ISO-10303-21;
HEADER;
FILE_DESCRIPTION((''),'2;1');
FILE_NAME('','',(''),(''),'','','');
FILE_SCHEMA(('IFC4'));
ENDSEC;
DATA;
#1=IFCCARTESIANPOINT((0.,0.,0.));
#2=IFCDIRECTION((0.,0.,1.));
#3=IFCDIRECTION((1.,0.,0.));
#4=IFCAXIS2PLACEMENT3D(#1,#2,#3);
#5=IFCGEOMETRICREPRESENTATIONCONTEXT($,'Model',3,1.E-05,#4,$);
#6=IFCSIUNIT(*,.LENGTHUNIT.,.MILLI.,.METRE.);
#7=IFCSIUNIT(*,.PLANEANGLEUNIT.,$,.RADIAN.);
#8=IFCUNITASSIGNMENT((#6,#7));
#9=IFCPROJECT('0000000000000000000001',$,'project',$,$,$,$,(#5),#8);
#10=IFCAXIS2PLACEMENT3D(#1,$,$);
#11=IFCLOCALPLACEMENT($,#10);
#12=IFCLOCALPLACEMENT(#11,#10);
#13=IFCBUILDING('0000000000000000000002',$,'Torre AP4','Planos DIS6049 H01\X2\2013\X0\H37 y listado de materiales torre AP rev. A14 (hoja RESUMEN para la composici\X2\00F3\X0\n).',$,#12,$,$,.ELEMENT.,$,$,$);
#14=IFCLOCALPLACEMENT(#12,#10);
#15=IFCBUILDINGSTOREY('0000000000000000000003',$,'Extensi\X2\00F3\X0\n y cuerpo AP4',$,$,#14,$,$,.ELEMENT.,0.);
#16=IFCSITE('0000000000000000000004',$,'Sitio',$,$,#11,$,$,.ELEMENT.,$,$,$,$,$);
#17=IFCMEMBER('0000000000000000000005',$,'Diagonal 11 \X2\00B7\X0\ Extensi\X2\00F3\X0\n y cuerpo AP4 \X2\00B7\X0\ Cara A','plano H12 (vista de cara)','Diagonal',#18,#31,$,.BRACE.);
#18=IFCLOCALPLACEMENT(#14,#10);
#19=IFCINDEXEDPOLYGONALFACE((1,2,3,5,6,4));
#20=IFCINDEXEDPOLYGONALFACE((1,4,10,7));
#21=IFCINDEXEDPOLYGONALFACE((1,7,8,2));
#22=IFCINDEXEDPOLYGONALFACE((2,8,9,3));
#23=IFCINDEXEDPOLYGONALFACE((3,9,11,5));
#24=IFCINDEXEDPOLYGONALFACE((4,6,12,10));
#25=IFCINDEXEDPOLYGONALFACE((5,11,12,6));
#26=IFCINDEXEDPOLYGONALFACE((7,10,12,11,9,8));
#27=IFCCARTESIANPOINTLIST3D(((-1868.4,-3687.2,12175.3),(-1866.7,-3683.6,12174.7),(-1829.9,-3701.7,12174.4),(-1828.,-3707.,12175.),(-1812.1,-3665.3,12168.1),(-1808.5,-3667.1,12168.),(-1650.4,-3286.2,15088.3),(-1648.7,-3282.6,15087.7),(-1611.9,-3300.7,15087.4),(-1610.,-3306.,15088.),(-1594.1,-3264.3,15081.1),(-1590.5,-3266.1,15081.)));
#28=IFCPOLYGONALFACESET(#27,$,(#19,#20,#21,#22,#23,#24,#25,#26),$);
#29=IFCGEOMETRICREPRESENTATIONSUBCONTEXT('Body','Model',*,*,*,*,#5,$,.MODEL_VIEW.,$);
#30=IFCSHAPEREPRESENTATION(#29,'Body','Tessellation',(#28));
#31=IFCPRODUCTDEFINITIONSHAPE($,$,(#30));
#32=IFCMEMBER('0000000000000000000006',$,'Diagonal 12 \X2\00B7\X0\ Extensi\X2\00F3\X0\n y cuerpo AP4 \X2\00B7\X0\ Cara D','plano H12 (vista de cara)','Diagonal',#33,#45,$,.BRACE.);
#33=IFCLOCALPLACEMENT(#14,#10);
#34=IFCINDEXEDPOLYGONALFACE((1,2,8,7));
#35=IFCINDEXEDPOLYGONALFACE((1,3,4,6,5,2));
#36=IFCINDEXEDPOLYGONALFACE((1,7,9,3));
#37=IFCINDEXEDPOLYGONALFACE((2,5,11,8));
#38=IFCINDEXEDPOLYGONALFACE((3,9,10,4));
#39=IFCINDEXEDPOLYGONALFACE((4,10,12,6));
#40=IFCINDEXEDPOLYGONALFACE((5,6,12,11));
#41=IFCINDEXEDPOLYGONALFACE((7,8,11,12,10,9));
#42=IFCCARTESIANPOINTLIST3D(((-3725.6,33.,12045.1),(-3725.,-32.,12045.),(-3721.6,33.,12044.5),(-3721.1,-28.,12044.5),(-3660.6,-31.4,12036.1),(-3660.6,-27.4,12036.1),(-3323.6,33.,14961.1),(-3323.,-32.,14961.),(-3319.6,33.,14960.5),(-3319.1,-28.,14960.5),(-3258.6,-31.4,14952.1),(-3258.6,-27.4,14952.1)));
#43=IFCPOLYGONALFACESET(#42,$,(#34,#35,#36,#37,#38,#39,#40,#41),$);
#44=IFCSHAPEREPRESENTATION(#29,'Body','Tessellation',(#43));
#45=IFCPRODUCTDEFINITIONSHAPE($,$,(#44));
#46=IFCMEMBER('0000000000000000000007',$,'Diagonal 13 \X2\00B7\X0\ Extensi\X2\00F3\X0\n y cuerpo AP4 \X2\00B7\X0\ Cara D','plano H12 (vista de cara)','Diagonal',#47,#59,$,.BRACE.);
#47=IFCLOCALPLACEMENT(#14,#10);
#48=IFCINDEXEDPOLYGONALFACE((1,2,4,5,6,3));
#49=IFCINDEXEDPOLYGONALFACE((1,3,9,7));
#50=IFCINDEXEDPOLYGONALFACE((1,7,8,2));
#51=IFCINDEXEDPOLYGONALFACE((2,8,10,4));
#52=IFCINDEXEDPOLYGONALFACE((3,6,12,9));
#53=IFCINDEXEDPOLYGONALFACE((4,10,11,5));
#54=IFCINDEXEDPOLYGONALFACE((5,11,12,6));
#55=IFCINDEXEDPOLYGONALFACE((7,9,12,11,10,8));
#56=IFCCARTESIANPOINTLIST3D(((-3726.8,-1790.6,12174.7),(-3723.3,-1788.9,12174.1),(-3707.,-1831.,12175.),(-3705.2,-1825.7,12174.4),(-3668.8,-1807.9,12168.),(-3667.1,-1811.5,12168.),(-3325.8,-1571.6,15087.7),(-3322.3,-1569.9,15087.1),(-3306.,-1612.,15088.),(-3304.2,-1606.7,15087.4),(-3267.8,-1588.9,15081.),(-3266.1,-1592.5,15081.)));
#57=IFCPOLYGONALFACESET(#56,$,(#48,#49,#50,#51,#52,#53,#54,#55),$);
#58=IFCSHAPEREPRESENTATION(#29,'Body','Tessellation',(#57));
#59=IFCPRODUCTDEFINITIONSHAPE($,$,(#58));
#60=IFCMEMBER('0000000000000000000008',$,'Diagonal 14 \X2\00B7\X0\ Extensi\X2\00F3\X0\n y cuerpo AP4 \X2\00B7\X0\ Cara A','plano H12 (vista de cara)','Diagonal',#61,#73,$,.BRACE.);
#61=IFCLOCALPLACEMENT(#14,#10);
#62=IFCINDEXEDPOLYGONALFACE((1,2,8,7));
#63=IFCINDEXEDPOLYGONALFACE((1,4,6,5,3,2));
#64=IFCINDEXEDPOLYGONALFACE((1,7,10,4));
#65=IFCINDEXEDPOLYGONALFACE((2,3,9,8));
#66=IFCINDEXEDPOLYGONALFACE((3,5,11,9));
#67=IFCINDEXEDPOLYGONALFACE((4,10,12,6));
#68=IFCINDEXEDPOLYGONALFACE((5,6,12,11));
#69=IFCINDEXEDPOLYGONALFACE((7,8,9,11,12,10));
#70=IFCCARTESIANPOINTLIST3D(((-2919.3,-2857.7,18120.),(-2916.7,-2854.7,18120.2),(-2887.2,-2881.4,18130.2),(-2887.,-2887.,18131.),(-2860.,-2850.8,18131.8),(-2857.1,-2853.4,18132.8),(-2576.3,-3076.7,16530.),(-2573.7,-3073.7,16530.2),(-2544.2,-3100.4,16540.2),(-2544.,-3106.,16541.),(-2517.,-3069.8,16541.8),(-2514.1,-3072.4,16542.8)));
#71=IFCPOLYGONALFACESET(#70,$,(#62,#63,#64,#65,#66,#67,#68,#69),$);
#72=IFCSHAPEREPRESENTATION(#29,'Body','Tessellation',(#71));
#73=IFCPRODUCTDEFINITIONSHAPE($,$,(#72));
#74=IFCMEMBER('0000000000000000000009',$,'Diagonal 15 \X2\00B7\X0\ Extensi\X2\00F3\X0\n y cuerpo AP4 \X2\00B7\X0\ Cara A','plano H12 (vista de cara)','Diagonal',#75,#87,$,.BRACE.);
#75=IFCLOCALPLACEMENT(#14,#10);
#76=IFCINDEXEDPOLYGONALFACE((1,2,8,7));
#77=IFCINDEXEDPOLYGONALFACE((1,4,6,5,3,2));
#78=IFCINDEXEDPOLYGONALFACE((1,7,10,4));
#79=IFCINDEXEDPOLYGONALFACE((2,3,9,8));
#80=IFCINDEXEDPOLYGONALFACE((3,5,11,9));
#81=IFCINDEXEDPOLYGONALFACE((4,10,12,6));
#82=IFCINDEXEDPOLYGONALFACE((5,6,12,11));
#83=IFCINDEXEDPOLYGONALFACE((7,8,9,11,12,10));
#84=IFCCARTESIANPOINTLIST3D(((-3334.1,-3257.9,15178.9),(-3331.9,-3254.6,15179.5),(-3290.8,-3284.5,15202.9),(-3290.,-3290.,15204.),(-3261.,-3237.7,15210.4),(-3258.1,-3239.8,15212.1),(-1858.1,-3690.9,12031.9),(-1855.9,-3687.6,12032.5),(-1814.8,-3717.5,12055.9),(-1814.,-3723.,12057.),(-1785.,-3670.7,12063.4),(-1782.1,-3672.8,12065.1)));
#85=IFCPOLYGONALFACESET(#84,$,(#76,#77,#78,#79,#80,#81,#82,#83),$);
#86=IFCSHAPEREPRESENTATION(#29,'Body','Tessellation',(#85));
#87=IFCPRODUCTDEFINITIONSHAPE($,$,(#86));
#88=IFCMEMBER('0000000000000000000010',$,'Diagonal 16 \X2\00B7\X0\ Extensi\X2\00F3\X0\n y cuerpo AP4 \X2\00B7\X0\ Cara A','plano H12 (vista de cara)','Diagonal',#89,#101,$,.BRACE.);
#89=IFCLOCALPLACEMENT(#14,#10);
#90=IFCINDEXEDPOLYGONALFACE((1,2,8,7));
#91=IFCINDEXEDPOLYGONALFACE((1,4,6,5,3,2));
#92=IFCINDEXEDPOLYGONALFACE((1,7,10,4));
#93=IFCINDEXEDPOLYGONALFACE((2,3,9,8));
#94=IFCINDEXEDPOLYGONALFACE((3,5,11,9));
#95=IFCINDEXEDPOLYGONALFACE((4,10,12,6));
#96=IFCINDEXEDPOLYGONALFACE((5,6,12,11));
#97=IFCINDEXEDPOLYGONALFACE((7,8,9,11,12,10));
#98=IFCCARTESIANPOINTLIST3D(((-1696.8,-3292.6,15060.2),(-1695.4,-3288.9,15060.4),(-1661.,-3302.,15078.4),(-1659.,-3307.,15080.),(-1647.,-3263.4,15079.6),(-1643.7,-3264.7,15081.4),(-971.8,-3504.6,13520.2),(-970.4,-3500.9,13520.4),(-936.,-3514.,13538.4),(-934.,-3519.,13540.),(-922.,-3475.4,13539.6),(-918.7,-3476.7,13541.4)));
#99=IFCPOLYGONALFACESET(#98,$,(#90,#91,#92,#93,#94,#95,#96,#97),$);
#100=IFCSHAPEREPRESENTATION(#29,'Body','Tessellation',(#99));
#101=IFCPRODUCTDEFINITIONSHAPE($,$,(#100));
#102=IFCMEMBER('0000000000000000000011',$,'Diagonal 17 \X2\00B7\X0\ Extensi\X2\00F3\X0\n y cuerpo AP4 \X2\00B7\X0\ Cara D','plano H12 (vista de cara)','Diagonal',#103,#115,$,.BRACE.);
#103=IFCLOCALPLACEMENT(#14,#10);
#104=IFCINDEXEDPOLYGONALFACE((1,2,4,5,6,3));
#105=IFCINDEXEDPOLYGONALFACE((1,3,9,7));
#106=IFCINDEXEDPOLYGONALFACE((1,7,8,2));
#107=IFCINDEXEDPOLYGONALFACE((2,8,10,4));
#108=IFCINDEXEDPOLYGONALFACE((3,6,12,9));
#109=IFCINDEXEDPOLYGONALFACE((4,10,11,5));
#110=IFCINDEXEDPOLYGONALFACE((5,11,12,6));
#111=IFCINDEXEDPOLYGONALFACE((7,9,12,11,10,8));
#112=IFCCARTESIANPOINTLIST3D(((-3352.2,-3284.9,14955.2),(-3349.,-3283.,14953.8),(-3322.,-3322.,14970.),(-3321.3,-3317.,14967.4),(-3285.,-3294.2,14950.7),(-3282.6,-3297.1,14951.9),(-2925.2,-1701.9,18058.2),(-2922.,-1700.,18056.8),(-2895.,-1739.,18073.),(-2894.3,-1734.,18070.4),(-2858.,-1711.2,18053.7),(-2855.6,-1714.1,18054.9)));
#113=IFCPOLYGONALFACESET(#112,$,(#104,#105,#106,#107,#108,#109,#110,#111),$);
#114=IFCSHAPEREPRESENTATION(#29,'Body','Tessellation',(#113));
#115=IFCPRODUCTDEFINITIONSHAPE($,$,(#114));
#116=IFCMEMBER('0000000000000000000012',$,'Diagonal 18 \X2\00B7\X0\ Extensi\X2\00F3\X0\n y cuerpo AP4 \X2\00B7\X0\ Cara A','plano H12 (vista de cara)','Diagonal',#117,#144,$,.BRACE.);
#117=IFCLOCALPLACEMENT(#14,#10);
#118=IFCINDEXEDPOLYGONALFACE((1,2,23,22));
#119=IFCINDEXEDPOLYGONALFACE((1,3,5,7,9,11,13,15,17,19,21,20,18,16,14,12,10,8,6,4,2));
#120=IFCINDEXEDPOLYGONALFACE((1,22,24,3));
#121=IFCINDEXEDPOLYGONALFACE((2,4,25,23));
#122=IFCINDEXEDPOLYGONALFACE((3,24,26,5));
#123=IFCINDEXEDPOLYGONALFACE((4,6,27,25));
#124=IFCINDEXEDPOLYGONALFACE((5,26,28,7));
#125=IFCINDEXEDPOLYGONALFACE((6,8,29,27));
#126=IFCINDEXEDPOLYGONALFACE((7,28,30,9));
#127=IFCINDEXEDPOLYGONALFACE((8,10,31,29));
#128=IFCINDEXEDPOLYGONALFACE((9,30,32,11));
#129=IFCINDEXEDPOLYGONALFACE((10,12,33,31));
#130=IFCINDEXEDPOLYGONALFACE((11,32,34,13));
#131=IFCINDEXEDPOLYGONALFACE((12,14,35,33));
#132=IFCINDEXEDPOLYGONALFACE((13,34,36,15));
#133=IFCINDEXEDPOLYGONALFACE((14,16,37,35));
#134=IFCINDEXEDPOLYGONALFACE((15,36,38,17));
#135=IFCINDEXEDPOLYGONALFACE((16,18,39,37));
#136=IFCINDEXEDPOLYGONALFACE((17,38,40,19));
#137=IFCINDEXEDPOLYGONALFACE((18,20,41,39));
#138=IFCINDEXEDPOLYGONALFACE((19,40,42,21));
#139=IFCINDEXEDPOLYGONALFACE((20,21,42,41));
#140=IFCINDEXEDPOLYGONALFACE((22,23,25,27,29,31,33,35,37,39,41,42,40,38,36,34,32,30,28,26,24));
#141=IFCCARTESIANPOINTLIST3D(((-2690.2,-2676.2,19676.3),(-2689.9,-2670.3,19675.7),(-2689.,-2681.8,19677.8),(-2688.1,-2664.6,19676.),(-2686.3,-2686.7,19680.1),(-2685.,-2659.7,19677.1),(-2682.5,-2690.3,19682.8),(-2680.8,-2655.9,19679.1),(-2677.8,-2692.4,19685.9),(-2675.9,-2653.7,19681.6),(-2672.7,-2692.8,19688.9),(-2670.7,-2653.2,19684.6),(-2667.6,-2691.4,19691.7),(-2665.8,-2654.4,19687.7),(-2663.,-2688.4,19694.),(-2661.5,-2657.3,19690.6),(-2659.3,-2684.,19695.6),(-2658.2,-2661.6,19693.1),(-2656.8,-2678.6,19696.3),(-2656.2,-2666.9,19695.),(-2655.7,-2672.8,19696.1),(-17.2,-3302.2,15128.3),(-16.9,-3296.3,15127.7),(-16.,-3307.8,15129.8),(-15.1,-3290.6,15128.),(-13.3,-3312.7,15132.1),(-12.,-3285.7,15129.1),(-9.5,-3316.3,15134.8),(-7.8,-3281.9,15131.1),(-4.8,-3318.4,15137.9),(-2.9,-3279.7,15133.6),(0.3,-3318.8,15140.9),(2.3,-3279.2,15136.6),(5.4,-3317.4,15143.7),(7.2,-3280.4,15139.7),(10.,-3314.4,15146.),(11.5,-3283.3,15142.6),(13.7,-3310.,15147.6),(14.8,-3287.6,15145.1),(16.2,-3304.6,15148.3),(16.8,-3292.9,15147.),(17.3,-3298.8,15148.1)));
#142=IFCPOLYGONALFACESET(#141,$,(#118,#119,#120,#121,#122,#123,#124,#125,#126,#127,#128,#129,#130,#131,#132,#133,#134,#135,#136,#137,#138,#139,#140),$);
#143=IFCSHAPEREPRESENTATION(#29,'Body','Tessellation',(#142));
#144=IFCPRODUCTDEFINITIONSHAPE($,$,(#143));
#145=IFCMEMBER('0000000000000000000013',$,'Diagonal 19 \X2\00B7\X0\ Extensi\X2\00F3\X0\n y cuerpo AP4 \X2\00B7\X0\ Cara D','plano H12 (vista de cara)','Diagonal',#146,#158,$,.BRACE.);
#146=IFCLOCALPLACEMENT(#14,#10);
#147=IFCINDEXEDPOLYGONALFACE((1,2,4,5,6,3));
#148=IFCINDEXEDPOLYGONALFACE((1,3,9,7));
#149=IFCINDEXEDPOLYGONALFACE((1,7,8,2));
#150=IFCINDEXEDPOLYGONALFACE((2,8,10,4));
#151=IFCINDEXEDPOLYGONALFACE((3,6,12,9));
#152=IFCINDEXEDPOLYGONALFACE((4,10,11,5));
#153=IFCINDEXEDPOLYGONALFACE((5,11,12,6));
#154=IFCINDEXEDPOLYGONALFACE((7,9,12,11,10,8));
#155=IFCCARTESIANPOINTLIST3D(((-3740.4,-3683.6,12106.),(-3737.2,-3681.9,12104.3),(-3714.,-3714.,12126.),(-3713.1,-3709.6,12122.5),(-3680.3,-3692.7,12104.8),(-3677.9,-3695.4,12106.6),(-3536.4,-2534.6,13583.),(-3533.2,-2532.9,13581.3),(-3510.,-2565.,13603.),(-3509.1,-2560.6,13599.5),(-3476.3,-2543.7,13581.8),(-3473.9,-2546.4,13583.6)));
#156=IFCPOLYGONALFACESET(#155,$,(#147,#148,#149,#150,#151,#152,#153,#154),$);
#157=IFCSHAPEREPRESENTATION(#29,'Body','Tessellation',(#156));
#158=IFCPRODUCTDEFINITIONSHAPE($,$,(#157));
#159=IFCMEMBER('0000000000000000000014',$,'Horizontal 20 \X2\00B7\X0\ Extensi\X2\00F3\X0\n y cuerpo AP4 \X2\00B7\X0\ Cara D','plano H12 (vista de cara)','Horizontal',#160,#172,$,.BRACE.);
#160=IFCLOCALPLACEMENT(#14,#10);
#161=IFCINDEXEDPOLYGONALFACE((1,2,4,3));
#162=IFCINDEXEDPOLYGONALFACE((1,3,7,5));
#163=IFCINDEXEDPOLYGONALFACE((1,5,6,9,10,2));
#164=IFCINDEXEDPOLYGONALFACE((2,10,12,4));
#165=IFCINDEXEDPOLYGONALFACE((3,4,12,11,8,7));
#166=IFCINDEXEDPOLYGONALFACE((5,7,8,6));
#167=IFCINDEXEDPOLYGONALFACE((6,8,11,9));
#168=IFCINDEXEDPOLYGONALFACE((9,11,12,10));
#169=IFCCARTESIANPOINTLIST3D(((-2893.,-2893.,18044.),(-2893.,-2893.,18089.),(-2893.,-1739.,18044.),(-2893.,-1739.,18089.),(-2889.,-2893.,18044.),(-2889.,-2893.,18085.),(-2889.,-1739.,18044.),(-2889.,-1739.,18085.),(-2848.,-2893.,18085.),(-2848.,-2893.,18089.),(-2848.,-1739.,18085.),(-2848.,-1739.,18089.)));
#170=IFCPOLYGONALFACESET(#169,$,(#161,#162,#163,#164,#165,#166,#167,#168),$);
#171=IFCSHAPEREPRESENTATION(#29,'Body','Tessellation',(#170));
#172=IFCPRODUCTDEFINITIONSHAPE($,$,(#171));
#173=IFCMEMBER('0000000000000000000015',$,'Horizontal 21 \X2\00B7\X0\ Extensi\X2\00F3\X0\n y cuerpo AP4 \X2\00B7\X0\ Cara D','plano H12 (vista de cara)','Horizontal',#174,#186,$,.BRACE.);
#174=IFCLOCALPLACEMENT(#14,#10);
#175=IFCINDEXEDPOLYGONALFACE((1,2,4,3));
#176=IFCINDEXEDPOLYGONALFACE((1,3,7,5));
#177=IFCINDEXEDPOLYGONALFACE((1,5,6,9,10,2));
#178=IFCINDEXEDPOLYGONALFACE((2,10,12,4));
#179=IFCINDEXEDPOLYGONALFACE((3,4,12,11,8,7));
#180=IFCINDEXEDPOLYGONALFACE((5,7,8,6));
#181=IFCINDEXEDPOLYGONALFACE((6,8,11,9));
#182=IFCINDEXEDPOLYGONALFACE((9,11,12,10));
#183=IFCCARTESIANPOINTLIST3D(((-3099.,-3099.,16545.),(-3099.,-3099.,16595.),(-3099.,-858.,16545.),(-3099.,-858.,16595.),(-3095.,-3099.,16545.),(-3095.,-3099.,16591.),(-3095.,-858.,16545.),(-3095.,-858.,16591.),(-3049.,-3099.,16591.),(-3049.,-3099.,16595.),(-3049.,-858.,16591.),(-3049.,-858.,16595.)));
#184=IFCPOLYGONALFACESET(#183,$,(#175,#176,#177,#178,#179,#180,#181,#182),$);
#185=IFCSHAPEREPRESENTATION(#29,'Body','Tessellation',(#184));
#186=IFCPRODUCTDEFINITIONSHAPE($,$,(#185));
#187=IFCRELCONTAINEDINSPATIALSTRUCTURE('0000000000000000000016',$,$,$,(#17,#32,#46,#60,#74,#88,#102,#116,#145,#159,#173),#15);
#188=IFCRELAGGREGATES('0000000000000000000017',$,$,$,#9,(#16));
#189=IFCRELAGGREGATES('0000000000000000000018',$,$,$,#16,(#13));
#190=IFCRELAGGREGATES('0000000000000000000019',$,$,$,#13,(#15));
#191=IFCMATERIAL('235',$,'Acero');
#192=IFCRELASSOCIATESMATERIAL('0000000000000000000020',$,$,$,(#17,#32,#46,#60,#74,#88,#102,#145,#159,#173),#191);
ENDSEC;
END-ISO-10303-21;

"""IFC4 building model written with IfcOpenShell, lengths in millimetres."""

from ifc_helpers import new_model, si_unit, frame, frame_2d, origin, origin_with_axes, place, context, subcontext, project, spatial, circle, l_section, extrude, material, element, save


model = new_model("IFC4")

# Units and contexts
model_context = context("Model", 3, precision=1e-05, world=origin_with_axes())
body_context = subcontext(model_context, "Body", "Model", "MODEL_VIEW")
ifc_project = project(units=[si_unit("LENGTHUNIT", "METRE", prefix="MILLI"), si_unit("PLANEANGLEUNIT", "RADIAN")], contexts=[model_context])

# Site, building, storey
site_placement = place(None, origin())
site = spatial("IfcSite", under=ifc_project, at=site_placement, Name="Sitio", CompositionType="ELEMENT")
building_placement = place(site_placement, origin())
building = spatial("IfcBuilding", under=site, at=building_placement, Name="Torre AP4", Description="Planos DIS6049 H01–H37 y listado de materiales torre AP rev. A14 (hoja RESUMEN para la composición).", CompositionType="ELEMENT")
storey_placement = place(building_placement, origin())
storey = spatial("IfcBuildingStorey", under=building, at=storey_placement, Name="Extensión y cuerpo AP4", CompositionType="ELEMENT", Elevation=0.0)

# Members
ifc_material_1 = material(Name="235", Category="Acero")
member_1_placement = place(storey_placement, frame((-1828.0, -3707.0, 12175.0), z_axis=(0.073935, 0.135999, 0.987946), x_axis=(0.43397, 0.887553, -0.154657)))
element("IfcMember", 1, at=member_1_placement, inside=storey, material=ifc_material_1, Name="Diagonal 11 · Extensión y cuerpo AP4 · Cara A", Description="plano H12 (vista de cara)", ObjectType="Diagonal", PredefinedType="BRACE", context=body_context, shape_type="SweptSolid", body=[
    extrude(l_section(Depth=45.0, Width=45.0, Thickness=4.0, at=frame_2d((22.5, 22.5))), None, (0.0, 0.0, 1.0), 2948.5),
])
member_2_placement = place(storey_placement, frame((-3725.0, -32.0, 12045.0), z_axis=(0.136568, 0.0, 0.990631), x_axis=(0.990589, 0.009166, -0.136563)))
element("IfcMember", 2, at=member_2_placement, inside=storey, material=ifc_material_1, Name="Diagonal 12 · Extensión y cuerpo AP4 · Cara D", Description="plano H12 (vista de cara)", ObjectType="Diagonal", PredefinedType="BRACE", context=body_context, shape_type="SweptSolid", body=[
    extrude(l_section(Depth=65.0, Width=65.0, Thickness=4.0, at=frame_2d((32.5, 32.5))), None, (0.0, 0.0, 1.0), 2943.6),
])
member_3_placement = place(storey_placement, frame((-3707.0, -1831.0, 12175.0), z_axis=(0.135996, 0.074272, 0.987921), x_axis=(0.887298, 0.434439, -0.154806)))
element("IfcMember", 3, at=member_3_placement, inside=storey, material=ifc_material_1, Name="Diagonal 13 · Extensión y cuerpo AP4 · Cara D", Description="plano H12 (vista de cara)", ObjectType="Diagonal", PredefinedType="BRACE", context=body_context, shape_type="SweptSolid", body=[
    extrude(l_section(Depth=45.0, Width=45.0, Thickness=4.0, at=frame_2d((22.5, 22.5))), None, (0.0, 0.0, 1.0), 2948.6),
])
member_4_placement = place(storey_placement, frame((-2544.0, -3106.0, 16541.0), z_axis=(-0.208987, 0.133435, 0.968772), x_axis=(0.663414, 0.747172, 0.040202)))
element("IfcMember", 4, at=member_4_placement, inside=storey, material=ifc_material_1, Name="Diagonal 14 · Extensión y cuerpo AP4 · Cara A", Description="plano H12 (vista de cara)", ObjectType="Diagonal", PredefinedType="BRACE", context=body_context, shape_type="SweptSolid", body=[
    extrude(l_section(Depth=45.0, Width=45.0, Thickness=4.0, at=frame_2d((22.5, 22.5))), None, (0.0, 0.0, 1.0), 1641.3),
])
member_5_placement = place(storey_placement, frame((-1814.0, -3723.0, 12057.0), z_axis=(-0.421376, 0.123615, 0.898422), x_axis=(0.531937, 0.836041, 0.134456)))
element("IfcMember", 5, at=member_5_placement, inside=storey, material=ifc_material_1, Name="Diagonal 15 · Extensión y cuerpo AP4 · Cara A", Description="plano H12 (vista de cara)", ObjectType="Diagonal", PredefinedType="BRACE", context=body_context, shape_type="SweptSolid", body=[
    extrude(l_section(Depth=60.0, Width=60.0, Thickness=4.0, at=frame_2d((30.0, 30.0))), None, (0.0, 0.0, 1.0), 3502.8),
])
member_6_placement = place(storey_placement, frame((-934.0, -3519.0, 13540.0), z_axis=(-0.422673, 0.123595, 0.897815), x_axis=(0.34071, 0.939656, 0.031044)))
element("IfcMember", 6, at=member_6_placement, inside=storey, material=ifc_material_1, Name="Diagonal 16 · Extensión y cuerpo AP4 · Cara A", Description="plano H12 (vista de cara)", ObjectType="Diagonal", PredefinedType="BRACE", context=body_context, shape_type="SweptSolid", body=[
    extrude(l_section(Depth=45.0, Width=45.0, Thickness=4.0, at=frame_2d((22.5, 22.5))), None, (0.0, 0.0, 1.0), 1715.3),
])
member_7_placement = place(storey_placement, frame((-3322.0, -3322.0, 14970.0), z_axis=(0.121669, 0.451057, 0.884163), x_axis=(0.788239, 0.497452, -0.362244)))
element("IfcMember", 7, at=member_7_placement, inside=storey, material=ifc_material_1, Name="Diagonal 17 · Extensión y cuerpo AP4 · Cara D", Description="plano H12 (vista de cara)", ObjectType="Diagonal", PredefinedType="BRACE", context=body_context, shape_type="SweptSolid", body=[
    extrude(l_section(Depth=50.0, Width=50.0, Thickness=4.0, at=frame_2d((25.0, 25.0))), None, (0.0, 0.0, 1.0), 3509.5),
])
member_8_placement = place(storey_placement, frame((0.0, -3299.0, 15138.0), z_axis=(-0.503167, 0.117839, 0.856118), x_axis=(0.360959, 0.928763, 0.084309)))
element("IfcMember", 8, at=member_8_placement, inside=storey, Name="Diagonal 18 · Extensión y cuerpo AP4 · Cara A", Description="plano H12 (vista de cara)", ObjectType="Diagonal", PredefinedType="BRACE", context=body_context, shape_type="SweptSolid", body=[
    extrude(circle(Radius=20.0), None, (0.0, 0.0, 1.0), 5312.4),
])
member_9_placement = place(storey_placement, frame((-3714.0, -3714.0, 12126.0), z_axis=(0.108374, 0.610398, 0.784646), x_axis=(0.801882, 0.412839, -0.431913)))
element("IfcMember", 9, at=member_9_placement, inside=storey, material=ifc_material_1, Name="Diagonal 19 · Extensión y cuerpo AP4 · Cara D", Description="plano H12 (vista de cara)", ObjectType="Diagonal", PredefinedType="BRACE", context=body_context, shape_type="SweptSolid", body=[
    extrude(l_section(Depth=45.0, Width=45.0, Thickness=4.0, at=frame_2d((22.5, 22.5))), None, (0.0, 0.0, 1.0), 1882.4),
])
member_10_placement = place(storey_placement, frame((-2893.0, -2893.0, 18089.0), z_axis=(0.0, 1.0, 0.0), x_axis=(1.0, 0.0, 0.0)))
element("IfcMember", 10, at=member_10_placement, inside=storey, material=ifc_material_1, Name="Horizontal 20 · Extensión y cuerpo AP4 · Cara D", Description="plano H12 (vista de cara)", ObjectType="Horizontal", PredefinedType="BRACE", context=body_context, shape_type="SweptSolid", body=[
    extrude(l_section(Depth=45.0, Width=45.0, Thickness=4.0, at=frame_2d((22.5, 22.5))), None, (0.0, 0.0, 1.0), 1154.0),
])
member_11_placement = place(storey_placement, frame((-3099.0, -3099.0, 16595.0), z_axis=(0.0, 1.0, 0.0), x_axis=(1.0, 0.0, 0.0)))
element("IfcMember", 11, at=member_11_placement, inside=storey, material=ifc_material_1, Name="Horizontal 21 · Extensión y cuerpo AP4 · Cara D", Description="plano H12 (vista de cara)", ObjectType="Horizontal", PredefinedType="BRACE", context=body_context, shape_type="SweptSolid", body=[
    extrude(l_section(Depth=50.0, Width=50.0, Thickness=4.0, at=frame_2d((25.0, 25.0))), None, (0.0, 0.0, 1.0), 2241.0),
])

save(model, "model.ifc")
